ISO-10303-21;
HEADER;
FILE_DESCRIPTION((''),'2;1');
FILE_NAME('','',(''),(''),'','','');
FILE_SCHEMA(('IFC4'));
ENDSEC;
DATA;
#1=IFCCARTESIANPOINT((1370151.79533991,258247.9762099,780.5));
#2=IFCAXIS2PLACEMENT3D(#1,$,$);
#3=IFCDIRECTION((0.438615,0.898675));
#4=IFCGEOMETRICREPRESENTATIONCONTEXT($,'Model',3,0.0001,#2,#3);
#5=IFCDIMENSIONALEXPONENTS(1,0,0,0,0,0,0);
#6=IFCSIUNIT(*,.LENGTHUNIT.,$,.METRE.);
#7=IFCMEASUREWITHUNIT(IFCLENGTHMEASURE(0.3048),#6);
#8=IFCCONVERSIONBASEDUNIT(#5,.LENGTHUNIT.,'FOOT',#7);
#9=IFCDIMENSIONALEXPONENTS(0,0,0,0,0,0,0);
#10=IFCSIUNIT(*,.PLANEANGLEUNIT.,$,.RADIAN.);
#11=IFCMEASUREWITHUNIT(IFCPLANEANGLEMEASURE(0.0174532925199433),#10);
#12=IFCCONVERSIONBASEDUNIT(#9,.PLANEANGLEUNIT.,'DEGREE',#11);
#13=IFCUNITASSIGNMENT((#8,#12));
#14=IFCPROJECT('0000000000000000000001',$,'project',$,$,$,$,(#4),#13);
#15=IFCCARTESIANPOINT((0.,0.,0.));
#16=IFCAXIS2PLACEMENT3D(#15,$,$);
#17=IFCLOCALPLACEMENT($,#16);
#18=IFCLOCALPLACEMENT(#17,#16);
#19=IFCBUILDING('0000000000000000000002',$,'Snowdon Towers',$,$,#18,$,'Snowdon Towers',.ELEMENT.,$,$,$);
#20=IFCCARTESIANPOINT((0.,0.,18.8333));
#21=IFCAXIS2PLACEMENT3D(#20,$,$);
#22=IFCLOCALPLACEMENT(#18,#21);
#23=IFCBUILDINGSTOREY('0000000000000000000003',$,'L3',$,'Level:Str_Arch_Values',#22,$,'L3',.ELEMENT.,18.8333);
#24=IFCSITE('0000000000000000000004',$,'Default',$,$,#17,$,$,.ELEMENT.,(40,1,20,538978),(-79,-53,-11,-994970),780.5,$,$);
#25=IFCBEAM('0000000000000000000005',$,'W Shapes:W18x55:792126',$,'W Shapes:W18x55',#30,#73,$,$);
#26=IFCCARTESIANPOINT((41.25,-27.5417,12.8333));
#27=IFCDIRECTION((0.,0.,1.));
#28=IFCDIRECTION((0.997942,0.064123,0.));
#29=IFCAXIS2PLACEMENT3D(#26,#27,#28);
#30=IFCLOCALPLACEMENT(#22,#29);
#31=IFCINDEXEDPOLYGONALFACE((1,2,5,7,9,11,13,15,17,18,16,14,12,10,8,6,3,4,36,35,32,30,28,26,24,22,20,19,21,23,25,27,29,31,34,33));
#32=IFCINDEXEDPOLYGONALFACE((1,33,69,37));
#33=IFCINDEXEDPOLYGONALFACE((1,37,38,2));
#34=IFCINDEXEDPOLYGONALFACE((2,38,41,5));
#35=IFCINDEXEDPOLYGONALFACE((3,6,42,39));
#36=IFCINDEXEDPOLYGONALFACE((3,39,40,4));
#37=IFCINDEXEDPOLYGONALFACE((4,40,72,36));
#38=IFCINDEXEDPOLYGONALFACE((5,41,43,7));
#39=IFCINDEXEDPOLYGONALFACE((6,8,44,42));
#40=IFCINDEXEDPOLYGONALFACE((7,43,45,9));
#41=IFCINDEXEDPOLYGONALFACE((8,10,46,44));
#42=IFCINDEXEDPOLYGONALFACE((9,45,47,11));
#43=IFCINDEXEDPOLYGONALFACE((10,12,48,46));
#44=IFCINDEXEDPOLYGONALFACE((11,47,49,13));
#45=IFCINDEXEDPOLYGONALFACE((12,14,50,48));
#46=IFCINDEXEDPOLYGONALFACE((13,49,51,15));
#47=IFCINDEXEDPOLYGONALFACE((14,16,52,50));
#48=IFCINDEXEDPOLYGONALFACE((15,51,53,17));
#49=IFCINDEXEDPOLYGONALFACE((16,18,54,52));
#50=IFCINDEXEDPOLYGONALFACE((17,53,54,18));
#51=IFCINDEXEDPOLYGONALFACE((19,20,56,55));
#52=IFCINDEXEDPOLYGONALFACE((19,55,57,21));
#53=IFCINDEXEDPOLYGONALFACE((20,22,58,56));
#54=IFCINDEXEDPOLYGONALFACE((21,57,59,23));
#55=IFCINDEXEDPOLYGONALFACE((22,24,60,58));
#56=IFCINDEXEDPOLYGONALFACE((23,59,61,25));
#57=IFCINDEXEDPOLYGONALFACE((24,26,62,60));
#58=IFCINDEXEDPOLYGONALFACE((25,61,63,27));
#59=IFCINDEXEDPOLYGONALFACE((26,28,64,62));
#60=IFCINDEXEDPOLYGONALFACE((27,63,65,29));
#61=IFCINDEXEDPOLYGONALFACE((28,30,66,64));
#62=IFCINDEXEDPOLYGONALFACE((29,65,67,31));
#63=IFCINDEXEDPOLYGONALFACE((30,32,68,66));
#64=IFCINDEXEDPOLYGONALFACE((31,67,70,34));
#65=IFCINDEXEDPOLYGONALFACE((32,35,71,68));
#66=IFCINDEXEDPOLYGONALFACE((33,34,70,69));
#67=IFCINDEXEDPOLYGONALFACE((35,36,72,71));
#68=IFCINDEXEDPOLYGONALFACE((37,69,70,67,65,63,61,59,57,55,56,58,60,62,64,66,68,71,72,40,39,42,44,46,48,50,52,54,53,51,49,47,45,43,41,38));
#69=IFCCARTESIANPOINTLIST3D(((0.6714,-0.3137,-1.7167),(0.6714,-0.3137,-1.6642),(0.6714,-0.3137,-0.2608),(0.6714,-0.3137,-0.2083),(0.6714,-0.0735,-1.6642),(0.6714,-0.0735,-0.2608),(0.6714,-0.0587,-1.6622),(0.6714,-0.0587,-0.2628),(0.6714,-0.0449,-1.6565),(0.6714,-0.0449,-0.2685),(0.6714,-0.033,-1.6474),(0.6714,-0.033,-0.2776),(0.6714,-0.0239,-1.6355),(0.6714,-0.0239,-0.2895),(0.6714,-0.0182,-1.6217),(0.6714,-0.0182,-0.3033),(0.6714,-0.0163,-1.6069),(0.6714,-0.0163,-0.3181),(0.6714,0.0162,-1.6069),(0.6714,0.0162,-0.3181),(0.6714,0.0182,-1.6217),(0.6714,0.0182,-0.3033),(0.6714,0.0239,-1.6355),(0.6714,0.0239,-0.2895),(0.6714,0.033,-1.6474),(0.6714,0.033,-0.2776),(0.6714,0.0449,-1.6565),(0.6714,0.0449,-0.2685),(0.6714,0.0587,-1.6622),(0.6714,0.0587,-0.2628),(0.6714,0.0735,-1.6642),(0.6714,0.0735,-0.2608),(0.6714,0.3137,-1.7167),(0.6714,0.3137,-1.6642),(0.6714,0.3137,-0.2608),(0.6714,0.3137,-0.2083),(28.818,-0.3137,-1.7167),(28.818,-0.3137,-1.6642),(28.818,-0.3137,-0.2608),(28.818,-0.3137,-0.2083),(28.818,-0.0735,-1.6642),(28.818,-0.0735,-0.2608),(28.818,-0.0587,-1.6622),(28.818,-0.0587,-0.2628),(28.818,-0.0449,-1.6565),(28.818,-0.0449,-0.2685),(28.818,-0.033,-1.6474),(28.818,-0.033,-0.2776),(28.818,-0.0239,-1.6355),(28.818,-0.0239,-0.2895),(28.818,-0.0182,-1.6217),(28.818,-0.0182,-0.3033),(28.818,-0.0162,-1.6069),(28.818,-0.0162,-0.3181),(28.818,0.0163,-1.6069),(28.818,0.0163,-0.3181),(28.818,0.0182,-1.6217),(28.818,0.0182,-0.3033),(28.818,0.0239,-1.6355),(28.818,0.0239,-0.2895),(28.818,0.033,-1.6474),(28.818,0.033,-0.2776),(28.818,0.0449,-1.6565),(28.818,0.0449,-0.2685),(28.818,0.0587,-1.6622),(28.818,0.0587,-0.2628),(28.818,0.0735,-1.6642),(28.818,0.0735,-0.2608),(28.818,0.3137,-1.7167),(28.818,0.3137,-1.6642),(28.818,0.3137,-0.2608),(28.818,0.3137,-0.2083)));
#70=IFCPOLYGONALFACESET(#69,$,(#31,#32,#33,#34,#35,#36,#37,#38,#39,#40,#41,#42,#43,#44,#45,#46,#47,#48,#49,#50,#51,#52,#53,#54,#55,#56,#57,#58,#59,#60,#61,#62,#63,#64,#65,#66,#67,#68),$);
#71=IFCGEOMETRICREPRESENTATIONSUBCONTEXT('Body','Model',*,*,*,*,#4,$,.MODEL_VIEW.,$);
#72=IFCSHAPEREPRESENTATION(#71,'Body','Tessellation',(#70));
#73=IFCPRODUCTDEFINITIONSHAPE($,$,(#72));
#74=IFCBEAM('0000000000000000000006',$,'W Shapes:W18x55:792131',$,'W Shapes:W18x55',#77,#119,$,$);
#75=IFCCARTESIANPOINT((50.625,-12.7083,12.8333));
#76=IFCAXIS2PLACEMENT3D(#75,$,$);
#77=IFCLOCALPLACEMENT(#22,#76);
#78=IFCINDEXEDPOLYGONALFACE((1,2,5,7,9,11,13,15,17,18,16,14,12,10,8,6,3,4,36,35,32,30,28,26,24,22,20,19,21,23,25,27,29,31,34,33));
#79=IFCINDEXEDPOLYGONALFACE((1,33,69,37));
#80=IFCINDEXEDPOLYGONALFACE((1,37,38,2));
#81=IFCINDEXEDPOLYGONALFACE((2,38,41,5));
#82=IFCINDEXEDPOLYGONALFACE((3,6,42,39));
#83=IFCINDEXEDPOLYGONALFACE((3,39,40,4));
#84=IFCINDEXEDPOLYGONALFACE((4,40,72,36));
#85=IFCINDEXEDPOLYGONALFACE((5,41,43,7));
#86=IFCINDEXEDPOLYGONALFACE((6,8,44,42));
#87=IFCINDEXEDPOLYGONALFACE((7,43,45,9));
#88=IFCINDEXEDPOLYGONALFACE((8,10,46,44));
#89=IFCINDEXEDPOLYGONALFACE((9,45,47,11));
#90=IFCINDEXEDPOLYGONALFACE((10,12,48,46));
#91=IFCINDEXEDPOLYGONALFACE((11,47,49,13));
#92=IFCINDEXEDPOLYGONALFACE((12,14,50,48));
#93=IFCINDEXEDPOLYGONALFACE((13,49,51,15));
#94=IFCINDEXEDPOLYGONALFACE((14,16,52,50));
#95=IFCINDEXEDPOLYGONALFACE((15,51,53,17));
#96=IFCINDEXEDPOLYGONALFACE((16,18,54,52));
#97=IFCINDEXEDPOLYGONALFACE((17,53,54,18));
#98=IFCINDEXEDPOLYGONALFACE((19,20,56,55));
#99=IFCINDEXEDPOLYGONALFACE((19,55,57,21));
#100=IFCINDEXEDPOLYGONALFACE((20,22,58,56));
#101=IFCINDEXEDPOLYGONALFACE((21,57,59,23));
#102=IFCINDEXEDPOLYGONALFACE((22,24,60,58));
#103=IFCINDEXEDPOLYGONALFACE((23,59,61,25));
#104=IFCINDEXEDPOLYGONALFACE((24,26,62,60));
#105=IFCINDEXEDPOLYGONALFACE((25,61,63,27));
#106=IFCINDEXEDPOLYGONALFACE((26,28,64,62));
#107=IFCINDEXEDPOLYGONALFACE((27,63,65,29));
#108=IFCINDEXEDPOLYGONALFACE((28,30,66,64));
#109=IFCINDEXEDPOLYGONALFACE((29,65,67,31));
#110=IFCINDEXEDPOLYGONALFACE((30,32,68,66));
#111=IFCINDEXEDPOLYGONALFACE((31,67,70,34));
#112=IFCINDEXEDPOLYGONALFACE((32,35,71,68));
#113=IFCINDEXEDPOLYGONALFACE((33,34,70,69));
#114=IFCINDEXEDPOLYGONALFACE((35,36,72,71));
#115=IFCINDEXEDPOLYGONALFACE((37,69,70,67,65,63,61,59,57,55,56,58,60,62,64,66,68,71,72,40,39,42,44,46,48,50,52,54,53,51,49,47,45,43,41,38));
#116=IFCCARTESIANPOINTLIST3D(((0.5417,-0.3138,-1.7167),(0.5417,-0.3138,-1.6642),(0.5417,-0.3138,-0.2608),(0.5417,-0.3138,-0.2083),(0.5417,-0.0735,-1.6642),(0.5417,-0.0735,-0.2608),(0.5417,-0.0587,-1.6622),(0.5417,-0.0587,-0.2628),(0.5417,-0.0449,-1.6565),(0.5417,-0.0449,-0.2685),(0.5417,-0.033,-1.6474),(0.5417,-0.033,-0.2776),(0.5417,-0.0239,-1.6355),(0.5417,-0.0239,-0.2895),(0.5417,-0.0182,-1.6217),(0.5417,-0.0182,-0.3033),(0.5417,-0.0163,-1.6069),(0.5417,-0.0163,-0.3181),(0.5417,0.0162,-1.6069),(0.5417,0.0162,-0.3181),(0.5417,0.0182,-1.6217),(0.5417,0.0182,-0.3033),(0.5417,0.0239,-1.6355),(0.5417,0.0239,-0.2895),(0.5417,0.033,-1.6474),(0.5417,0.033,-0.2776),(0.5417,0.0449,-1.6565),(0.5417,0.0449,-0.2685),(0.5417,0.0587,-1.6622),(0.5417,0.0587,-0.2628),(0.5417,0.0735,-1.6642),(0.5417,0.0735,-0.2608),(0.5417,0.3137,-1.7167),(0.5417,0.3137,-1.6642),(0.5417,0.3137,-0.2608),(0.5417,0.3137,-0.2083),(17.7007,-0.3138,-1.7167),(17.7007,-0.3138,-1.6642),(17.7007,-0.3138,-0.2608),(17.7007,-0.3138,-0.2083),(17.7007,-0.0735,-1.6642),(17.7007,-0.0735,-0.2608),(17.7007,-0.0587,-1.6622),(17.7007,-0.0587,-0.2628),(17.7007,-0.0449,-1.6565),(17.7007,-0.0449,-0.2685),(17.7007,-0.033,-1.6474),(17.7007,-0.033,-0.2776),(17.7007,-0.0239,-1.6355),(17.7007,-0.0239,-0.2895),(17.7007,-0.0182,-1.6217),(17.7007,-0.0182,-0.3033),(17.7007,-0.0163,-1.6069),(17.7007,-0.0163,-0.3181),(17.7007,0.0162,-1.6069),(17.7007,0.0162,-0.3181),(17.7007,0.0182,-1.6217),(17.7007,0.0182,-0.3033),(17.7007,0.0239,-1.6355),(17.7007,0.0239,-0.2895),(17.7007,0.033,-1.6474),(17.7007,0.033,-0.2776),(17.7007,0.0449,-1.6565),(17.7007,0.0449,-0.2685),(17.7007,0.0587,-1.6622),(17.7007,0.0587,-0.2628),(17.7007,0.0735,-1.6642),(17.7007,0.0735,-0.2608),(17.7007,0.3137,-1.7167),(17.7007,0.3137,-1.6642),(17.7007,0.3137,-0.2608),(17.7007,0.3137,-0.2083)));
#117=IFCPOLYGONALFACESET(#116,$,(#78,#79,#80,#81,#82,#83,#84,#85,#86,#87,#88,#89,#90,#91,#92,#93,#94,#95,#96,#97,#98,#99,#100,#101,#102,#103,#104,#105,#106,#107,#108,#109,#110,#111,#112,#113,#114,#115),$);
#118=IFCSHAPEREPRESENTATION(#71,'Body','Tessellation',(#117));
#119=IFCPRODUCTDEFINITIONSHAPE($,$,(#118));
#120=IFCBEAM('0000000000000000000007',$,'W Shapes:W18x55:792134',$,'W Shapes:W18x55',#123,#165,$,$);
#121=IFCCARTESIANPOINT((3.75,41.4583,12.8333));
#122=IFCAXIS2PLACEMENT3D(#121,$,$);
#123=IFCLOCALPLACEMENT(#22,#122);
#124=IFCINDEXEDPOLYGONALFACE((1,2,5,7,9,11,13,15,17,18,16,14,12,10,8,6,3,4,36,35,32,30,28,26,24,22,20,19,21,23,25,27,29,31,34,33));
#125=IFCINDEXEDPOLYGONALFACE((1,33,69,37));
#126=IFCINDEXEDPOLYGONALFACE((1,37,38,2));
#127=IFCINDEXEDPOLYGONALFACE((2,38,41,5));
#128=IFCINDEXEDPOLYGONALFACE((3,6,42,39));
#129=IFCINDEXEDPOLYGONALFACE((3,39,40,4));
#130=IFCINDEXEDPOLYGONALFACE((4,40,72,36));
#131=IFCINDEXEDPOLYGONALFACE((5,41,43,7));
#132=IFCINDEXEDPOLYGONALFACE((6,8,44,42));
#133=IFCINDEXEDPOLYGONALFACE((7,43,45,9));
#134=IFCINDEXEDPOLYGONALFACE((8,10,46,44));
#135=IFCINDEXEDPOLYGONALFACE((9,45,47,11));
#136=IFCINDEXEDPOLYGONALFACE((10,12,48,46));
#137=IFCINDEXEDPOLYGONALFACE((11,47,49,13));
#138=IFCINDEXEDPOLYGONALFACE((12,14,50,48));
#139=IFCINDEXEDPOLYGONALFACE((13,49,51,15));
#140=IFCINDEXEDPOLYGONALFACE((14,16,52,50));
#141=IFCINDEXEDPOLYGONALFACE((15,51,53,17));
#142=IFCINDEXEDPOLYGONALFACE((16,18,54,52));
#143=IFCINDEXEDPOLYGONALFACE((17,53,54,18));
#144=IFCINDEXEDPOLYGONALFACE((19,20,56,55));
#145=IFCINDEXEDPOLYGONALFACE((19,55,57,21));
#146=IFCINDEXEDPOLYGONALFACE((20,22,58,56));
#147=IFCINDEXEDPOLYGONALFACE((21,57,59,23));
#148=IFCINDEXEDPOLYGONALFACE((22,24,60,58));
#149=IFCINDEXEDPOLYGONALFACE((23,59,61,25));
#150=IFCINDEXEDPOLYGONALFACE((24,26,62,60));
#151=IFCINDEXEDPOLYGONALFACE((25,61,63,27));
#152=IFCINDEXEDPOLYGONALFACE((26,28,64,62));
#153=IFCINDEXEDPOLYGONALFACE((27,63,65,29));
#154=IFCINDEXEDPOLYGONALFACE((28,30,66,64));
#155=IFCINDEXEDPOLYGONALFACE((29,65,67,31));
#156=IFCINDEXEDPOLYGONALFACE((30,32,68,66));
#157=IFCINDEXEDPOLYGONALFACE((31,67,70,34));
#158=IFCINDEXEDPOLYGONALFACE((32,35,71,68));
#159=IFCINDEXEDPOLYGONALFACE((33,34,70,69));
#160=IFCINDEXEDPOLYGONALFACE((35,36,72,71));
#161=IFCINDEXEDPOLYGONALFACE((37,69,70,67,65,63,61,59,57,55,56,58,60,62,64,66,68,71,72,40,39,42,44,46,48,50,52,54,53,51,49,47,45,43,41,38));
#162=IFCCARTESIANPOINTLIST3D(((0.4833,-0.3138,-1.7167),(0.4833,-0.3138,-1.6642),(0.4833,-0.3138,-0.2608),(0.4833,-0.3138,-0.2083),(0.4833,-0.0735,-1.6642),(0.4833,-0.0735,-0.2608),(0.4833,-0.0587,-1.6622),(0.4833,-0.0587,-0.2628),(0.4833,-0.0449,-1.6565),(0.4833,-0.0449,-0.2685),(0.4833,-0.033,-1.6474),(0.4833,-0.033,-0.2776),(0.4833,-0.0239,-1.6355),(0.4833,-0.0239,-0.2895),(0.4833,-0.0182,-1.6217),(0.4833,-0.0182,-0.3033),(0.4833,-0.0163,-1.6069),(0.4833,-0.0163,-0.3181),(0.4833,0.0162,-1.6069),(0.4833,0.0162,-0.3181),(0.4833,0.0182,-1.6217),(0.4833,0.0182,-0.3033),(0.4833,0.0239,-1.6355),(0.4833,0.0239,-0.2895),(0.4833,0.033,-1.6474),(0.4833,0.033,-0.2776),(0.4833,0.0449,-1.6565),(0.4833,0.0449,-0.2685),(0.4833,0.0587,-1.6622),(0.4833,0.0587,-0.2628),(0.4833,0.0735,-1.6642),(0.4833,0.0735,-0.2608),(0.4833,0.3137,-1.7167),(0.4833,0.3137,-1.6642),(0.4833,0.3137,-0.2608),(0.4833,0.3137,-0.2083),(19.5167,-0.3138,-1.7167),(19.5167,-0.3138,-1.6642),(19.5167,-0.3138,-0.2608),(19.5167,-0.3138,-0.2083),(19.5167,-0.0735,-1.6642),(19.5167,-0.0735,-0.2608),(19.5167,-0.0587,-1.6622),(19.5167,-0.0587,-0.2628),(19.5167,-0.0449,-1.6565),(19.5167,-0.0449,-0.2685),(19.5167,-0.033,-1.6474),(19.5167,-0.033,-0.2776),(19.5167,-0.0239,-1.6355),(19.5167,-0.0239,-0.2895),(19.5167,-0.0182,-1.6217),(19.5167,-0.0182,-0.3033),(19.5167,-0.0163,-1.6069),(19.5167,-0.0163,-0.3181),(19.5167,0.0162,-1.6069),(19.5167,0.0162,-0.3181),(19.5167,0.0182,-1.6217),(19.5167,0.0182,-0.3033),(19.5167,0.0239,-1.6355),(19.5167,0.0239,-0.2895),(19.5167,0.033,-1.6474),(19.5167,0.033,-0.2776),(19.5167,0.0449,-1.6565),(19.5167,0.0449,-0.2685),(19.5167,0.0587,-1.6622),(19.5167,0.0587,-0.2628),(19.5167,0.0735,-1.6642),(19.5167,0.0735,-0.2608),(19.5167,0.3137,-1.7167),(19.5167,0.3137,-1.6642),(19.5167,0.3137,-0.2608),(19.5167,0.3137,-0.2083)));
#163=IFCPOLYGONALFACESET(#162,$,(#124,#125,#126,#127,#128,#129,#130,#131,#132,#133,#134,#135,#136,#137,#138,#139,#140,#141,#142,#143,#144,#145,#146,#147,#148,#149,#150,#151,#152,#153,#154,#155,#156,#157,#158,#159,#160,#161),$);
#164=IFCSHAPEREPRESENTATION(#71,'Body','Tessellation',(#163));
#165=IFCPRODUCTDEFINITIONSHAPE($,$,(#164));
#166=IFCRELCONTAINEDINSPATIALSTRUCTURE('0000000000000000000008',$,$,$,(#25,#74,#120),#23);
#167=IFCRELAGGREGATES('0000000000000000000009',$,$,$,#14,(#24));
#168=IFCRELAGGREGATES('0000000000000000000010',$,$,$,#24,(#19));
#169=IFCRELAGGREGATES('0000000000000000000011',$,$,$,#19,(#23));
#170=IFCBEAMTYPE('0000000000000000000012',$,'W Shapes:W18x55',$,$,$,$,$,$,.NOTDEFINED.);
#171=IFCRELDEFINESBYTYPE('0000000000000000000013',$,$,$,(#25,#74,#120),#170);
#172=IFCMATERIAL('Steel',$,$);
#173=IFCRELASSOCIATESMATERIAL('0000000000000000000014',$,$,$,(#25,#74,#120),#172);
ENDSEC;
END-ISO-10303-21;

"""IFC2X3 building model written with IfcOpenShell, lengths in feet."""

from ifc_helpers import new_model, entity, si_unit, converted_unit, direction, frame, frame_2d, origin, place, context, subcontext, project, spatial, i_section, extrude, material, type_object, element, save


model = new_model("IFC2X3")

# Units and contexts
model_context = context("Model", 3, precision=0.0001, world=frame((1370151.79533991, 258247.9762099, 780.5)), true_north=direction((0.438615, 0.898675)))
body_context = subcontext(model_context, "Body", "Model", "MODEL_VIEW")
ifc_project = project(units=[converted_unit("LENGTHUNIT", "FOOT", entity("IfcLengthMeasure", 0.3048), si_unit("LENGTHUNIT", "METRE"), dimensions=[1, 0, 0, 0, 0, 0, 0]), converted_unit("PLANEANGLEUNIT", "DEGREE", entity("IfcPlaneAngleMeasure", 0.0174532925199433), si_unit("PLANEANGLEUNIT", "RADIAN"), dimensions=[0, 0, 0, 0, 0, 0, 0])], contexts=[model_context])

# Site, building, storey
site_placement = place(None, origin())
site = spatial("IfcSite", under=ifc_project, at=site_placement, Name="Default", CompositionType="ELEMENT", RefLatitude=(40, 1, 20, 538978), RefLongitude=(-79, -53, -11, -994970), RefElevation=780.5)
building_placement = place(site_placement, origin())
building = spatial("IfcBuilding", under=site, at=building_placement, Name="Snowdon Towers", LongName="Snowdon Towers", CompositionType="ELEMENT")
storey_placement = place(building_placement, frame((0.0, 0.0, 18.8333)))
storey = spatial("IfcBuildingStorey", under=building, at=storey_placement, Name="L3", ObjectType="Level:Str_Arch_Values", LongName="L3", CompositionType="ELEMENT", Elevation=18.8333)

# Beams
ifc_material = material(Name="Steel")
beam_type_1 = type_object("IfcBeamType", Name="W Shapes:W18x55", PredefinedType="NOTDEFINED")
beam_1_placement = place(storey_placement, frame((41.25, -27.5417, 12.8333), z_axis=(0.0, 0.0, 1.0), x_axis=(0.997942, 0.064123, 0.0)))
element("IfcBeam", 1, at=beam_1_placement, inside=storey, type_object=beam_type_1, material=ifc_material, Name="W Shapes:W18x55:792126", ObjectType="W Shapes:W18x55", context=body_context, shape_type="SweptSolid", body=[
    extrude(i_section(OverallWidth=0.6275, OverallDepth=1.5083, WebThickness=0.0325, FlangeThickness=0.0525, FilletRadius=0.0573, at=frame_2d((0.0, 0.0), x_axis=(0.0, 1.0))), frame((0.6714, 0.0, -0.9625), z_axis=(1.0, 0.0, 0.0), x_axis=(0.0, 0.0, -1.0)), (0.0, 0.0, 1.0), 28.1466),
])
beam_2_placement = place(storey_placement, frame((50.625, -12.7083, 12.8333)))
element("IfcBeam", 2, at=beam_2_placement, inside=storey, type_object=beam_type_1, material=ifc_material, Name="W Shapes:W18x55:792131", ObjectType="W Shapes:W18x55", context=body_context, shape_type="SweptSolid", body=[
    extrude(i_section(OverallWidth=0.6275, OverallDepth=1.5083, WebThickness=0.0325, FlangeThickness=0.0525, FilletRadius=0.0573, at=frame_2d((0.0, 0.0), x_axis=(0.0, 1.0))), frame((0.5417, 0.0, -0.9625), z_axis=(1.0, 0.0, 0.0), x_axis=(0.0, 0.0, -1.0)), (0.0, 0.0, 1.0), 17.159),
])
beam_3_placement = place(storey_placement, frame((3.75, 41.4583, 12.8333)))
element("IfcBeam", 3, at=beam_3_placement, inside=storey, type_object=beam_type_1, material=ifc_material, Name="W Shapes:W18x55:792134", ObjectType="W Shapes:W18x55", context=body_context, shape_type="SweptSolid", body=[
    extrude(i_section(OverallWidth=0.6275, OverallDepth=1.5083, WebThickness=0.0325, FlangeThickness=0.0525, FilletRadius=0.0573, at=frame_2d((0.0, 0.0), x_axis=(0.0, 1.0))), frame((0.4833, 0.0, -0.9625), z_axis=(1.0, 0.0, 0.0), x_axis=(0.0, 0.0, -1.0)), (0.0, 0.0, 1.0), 19.0333),
])

save(model, "model.ifc")
